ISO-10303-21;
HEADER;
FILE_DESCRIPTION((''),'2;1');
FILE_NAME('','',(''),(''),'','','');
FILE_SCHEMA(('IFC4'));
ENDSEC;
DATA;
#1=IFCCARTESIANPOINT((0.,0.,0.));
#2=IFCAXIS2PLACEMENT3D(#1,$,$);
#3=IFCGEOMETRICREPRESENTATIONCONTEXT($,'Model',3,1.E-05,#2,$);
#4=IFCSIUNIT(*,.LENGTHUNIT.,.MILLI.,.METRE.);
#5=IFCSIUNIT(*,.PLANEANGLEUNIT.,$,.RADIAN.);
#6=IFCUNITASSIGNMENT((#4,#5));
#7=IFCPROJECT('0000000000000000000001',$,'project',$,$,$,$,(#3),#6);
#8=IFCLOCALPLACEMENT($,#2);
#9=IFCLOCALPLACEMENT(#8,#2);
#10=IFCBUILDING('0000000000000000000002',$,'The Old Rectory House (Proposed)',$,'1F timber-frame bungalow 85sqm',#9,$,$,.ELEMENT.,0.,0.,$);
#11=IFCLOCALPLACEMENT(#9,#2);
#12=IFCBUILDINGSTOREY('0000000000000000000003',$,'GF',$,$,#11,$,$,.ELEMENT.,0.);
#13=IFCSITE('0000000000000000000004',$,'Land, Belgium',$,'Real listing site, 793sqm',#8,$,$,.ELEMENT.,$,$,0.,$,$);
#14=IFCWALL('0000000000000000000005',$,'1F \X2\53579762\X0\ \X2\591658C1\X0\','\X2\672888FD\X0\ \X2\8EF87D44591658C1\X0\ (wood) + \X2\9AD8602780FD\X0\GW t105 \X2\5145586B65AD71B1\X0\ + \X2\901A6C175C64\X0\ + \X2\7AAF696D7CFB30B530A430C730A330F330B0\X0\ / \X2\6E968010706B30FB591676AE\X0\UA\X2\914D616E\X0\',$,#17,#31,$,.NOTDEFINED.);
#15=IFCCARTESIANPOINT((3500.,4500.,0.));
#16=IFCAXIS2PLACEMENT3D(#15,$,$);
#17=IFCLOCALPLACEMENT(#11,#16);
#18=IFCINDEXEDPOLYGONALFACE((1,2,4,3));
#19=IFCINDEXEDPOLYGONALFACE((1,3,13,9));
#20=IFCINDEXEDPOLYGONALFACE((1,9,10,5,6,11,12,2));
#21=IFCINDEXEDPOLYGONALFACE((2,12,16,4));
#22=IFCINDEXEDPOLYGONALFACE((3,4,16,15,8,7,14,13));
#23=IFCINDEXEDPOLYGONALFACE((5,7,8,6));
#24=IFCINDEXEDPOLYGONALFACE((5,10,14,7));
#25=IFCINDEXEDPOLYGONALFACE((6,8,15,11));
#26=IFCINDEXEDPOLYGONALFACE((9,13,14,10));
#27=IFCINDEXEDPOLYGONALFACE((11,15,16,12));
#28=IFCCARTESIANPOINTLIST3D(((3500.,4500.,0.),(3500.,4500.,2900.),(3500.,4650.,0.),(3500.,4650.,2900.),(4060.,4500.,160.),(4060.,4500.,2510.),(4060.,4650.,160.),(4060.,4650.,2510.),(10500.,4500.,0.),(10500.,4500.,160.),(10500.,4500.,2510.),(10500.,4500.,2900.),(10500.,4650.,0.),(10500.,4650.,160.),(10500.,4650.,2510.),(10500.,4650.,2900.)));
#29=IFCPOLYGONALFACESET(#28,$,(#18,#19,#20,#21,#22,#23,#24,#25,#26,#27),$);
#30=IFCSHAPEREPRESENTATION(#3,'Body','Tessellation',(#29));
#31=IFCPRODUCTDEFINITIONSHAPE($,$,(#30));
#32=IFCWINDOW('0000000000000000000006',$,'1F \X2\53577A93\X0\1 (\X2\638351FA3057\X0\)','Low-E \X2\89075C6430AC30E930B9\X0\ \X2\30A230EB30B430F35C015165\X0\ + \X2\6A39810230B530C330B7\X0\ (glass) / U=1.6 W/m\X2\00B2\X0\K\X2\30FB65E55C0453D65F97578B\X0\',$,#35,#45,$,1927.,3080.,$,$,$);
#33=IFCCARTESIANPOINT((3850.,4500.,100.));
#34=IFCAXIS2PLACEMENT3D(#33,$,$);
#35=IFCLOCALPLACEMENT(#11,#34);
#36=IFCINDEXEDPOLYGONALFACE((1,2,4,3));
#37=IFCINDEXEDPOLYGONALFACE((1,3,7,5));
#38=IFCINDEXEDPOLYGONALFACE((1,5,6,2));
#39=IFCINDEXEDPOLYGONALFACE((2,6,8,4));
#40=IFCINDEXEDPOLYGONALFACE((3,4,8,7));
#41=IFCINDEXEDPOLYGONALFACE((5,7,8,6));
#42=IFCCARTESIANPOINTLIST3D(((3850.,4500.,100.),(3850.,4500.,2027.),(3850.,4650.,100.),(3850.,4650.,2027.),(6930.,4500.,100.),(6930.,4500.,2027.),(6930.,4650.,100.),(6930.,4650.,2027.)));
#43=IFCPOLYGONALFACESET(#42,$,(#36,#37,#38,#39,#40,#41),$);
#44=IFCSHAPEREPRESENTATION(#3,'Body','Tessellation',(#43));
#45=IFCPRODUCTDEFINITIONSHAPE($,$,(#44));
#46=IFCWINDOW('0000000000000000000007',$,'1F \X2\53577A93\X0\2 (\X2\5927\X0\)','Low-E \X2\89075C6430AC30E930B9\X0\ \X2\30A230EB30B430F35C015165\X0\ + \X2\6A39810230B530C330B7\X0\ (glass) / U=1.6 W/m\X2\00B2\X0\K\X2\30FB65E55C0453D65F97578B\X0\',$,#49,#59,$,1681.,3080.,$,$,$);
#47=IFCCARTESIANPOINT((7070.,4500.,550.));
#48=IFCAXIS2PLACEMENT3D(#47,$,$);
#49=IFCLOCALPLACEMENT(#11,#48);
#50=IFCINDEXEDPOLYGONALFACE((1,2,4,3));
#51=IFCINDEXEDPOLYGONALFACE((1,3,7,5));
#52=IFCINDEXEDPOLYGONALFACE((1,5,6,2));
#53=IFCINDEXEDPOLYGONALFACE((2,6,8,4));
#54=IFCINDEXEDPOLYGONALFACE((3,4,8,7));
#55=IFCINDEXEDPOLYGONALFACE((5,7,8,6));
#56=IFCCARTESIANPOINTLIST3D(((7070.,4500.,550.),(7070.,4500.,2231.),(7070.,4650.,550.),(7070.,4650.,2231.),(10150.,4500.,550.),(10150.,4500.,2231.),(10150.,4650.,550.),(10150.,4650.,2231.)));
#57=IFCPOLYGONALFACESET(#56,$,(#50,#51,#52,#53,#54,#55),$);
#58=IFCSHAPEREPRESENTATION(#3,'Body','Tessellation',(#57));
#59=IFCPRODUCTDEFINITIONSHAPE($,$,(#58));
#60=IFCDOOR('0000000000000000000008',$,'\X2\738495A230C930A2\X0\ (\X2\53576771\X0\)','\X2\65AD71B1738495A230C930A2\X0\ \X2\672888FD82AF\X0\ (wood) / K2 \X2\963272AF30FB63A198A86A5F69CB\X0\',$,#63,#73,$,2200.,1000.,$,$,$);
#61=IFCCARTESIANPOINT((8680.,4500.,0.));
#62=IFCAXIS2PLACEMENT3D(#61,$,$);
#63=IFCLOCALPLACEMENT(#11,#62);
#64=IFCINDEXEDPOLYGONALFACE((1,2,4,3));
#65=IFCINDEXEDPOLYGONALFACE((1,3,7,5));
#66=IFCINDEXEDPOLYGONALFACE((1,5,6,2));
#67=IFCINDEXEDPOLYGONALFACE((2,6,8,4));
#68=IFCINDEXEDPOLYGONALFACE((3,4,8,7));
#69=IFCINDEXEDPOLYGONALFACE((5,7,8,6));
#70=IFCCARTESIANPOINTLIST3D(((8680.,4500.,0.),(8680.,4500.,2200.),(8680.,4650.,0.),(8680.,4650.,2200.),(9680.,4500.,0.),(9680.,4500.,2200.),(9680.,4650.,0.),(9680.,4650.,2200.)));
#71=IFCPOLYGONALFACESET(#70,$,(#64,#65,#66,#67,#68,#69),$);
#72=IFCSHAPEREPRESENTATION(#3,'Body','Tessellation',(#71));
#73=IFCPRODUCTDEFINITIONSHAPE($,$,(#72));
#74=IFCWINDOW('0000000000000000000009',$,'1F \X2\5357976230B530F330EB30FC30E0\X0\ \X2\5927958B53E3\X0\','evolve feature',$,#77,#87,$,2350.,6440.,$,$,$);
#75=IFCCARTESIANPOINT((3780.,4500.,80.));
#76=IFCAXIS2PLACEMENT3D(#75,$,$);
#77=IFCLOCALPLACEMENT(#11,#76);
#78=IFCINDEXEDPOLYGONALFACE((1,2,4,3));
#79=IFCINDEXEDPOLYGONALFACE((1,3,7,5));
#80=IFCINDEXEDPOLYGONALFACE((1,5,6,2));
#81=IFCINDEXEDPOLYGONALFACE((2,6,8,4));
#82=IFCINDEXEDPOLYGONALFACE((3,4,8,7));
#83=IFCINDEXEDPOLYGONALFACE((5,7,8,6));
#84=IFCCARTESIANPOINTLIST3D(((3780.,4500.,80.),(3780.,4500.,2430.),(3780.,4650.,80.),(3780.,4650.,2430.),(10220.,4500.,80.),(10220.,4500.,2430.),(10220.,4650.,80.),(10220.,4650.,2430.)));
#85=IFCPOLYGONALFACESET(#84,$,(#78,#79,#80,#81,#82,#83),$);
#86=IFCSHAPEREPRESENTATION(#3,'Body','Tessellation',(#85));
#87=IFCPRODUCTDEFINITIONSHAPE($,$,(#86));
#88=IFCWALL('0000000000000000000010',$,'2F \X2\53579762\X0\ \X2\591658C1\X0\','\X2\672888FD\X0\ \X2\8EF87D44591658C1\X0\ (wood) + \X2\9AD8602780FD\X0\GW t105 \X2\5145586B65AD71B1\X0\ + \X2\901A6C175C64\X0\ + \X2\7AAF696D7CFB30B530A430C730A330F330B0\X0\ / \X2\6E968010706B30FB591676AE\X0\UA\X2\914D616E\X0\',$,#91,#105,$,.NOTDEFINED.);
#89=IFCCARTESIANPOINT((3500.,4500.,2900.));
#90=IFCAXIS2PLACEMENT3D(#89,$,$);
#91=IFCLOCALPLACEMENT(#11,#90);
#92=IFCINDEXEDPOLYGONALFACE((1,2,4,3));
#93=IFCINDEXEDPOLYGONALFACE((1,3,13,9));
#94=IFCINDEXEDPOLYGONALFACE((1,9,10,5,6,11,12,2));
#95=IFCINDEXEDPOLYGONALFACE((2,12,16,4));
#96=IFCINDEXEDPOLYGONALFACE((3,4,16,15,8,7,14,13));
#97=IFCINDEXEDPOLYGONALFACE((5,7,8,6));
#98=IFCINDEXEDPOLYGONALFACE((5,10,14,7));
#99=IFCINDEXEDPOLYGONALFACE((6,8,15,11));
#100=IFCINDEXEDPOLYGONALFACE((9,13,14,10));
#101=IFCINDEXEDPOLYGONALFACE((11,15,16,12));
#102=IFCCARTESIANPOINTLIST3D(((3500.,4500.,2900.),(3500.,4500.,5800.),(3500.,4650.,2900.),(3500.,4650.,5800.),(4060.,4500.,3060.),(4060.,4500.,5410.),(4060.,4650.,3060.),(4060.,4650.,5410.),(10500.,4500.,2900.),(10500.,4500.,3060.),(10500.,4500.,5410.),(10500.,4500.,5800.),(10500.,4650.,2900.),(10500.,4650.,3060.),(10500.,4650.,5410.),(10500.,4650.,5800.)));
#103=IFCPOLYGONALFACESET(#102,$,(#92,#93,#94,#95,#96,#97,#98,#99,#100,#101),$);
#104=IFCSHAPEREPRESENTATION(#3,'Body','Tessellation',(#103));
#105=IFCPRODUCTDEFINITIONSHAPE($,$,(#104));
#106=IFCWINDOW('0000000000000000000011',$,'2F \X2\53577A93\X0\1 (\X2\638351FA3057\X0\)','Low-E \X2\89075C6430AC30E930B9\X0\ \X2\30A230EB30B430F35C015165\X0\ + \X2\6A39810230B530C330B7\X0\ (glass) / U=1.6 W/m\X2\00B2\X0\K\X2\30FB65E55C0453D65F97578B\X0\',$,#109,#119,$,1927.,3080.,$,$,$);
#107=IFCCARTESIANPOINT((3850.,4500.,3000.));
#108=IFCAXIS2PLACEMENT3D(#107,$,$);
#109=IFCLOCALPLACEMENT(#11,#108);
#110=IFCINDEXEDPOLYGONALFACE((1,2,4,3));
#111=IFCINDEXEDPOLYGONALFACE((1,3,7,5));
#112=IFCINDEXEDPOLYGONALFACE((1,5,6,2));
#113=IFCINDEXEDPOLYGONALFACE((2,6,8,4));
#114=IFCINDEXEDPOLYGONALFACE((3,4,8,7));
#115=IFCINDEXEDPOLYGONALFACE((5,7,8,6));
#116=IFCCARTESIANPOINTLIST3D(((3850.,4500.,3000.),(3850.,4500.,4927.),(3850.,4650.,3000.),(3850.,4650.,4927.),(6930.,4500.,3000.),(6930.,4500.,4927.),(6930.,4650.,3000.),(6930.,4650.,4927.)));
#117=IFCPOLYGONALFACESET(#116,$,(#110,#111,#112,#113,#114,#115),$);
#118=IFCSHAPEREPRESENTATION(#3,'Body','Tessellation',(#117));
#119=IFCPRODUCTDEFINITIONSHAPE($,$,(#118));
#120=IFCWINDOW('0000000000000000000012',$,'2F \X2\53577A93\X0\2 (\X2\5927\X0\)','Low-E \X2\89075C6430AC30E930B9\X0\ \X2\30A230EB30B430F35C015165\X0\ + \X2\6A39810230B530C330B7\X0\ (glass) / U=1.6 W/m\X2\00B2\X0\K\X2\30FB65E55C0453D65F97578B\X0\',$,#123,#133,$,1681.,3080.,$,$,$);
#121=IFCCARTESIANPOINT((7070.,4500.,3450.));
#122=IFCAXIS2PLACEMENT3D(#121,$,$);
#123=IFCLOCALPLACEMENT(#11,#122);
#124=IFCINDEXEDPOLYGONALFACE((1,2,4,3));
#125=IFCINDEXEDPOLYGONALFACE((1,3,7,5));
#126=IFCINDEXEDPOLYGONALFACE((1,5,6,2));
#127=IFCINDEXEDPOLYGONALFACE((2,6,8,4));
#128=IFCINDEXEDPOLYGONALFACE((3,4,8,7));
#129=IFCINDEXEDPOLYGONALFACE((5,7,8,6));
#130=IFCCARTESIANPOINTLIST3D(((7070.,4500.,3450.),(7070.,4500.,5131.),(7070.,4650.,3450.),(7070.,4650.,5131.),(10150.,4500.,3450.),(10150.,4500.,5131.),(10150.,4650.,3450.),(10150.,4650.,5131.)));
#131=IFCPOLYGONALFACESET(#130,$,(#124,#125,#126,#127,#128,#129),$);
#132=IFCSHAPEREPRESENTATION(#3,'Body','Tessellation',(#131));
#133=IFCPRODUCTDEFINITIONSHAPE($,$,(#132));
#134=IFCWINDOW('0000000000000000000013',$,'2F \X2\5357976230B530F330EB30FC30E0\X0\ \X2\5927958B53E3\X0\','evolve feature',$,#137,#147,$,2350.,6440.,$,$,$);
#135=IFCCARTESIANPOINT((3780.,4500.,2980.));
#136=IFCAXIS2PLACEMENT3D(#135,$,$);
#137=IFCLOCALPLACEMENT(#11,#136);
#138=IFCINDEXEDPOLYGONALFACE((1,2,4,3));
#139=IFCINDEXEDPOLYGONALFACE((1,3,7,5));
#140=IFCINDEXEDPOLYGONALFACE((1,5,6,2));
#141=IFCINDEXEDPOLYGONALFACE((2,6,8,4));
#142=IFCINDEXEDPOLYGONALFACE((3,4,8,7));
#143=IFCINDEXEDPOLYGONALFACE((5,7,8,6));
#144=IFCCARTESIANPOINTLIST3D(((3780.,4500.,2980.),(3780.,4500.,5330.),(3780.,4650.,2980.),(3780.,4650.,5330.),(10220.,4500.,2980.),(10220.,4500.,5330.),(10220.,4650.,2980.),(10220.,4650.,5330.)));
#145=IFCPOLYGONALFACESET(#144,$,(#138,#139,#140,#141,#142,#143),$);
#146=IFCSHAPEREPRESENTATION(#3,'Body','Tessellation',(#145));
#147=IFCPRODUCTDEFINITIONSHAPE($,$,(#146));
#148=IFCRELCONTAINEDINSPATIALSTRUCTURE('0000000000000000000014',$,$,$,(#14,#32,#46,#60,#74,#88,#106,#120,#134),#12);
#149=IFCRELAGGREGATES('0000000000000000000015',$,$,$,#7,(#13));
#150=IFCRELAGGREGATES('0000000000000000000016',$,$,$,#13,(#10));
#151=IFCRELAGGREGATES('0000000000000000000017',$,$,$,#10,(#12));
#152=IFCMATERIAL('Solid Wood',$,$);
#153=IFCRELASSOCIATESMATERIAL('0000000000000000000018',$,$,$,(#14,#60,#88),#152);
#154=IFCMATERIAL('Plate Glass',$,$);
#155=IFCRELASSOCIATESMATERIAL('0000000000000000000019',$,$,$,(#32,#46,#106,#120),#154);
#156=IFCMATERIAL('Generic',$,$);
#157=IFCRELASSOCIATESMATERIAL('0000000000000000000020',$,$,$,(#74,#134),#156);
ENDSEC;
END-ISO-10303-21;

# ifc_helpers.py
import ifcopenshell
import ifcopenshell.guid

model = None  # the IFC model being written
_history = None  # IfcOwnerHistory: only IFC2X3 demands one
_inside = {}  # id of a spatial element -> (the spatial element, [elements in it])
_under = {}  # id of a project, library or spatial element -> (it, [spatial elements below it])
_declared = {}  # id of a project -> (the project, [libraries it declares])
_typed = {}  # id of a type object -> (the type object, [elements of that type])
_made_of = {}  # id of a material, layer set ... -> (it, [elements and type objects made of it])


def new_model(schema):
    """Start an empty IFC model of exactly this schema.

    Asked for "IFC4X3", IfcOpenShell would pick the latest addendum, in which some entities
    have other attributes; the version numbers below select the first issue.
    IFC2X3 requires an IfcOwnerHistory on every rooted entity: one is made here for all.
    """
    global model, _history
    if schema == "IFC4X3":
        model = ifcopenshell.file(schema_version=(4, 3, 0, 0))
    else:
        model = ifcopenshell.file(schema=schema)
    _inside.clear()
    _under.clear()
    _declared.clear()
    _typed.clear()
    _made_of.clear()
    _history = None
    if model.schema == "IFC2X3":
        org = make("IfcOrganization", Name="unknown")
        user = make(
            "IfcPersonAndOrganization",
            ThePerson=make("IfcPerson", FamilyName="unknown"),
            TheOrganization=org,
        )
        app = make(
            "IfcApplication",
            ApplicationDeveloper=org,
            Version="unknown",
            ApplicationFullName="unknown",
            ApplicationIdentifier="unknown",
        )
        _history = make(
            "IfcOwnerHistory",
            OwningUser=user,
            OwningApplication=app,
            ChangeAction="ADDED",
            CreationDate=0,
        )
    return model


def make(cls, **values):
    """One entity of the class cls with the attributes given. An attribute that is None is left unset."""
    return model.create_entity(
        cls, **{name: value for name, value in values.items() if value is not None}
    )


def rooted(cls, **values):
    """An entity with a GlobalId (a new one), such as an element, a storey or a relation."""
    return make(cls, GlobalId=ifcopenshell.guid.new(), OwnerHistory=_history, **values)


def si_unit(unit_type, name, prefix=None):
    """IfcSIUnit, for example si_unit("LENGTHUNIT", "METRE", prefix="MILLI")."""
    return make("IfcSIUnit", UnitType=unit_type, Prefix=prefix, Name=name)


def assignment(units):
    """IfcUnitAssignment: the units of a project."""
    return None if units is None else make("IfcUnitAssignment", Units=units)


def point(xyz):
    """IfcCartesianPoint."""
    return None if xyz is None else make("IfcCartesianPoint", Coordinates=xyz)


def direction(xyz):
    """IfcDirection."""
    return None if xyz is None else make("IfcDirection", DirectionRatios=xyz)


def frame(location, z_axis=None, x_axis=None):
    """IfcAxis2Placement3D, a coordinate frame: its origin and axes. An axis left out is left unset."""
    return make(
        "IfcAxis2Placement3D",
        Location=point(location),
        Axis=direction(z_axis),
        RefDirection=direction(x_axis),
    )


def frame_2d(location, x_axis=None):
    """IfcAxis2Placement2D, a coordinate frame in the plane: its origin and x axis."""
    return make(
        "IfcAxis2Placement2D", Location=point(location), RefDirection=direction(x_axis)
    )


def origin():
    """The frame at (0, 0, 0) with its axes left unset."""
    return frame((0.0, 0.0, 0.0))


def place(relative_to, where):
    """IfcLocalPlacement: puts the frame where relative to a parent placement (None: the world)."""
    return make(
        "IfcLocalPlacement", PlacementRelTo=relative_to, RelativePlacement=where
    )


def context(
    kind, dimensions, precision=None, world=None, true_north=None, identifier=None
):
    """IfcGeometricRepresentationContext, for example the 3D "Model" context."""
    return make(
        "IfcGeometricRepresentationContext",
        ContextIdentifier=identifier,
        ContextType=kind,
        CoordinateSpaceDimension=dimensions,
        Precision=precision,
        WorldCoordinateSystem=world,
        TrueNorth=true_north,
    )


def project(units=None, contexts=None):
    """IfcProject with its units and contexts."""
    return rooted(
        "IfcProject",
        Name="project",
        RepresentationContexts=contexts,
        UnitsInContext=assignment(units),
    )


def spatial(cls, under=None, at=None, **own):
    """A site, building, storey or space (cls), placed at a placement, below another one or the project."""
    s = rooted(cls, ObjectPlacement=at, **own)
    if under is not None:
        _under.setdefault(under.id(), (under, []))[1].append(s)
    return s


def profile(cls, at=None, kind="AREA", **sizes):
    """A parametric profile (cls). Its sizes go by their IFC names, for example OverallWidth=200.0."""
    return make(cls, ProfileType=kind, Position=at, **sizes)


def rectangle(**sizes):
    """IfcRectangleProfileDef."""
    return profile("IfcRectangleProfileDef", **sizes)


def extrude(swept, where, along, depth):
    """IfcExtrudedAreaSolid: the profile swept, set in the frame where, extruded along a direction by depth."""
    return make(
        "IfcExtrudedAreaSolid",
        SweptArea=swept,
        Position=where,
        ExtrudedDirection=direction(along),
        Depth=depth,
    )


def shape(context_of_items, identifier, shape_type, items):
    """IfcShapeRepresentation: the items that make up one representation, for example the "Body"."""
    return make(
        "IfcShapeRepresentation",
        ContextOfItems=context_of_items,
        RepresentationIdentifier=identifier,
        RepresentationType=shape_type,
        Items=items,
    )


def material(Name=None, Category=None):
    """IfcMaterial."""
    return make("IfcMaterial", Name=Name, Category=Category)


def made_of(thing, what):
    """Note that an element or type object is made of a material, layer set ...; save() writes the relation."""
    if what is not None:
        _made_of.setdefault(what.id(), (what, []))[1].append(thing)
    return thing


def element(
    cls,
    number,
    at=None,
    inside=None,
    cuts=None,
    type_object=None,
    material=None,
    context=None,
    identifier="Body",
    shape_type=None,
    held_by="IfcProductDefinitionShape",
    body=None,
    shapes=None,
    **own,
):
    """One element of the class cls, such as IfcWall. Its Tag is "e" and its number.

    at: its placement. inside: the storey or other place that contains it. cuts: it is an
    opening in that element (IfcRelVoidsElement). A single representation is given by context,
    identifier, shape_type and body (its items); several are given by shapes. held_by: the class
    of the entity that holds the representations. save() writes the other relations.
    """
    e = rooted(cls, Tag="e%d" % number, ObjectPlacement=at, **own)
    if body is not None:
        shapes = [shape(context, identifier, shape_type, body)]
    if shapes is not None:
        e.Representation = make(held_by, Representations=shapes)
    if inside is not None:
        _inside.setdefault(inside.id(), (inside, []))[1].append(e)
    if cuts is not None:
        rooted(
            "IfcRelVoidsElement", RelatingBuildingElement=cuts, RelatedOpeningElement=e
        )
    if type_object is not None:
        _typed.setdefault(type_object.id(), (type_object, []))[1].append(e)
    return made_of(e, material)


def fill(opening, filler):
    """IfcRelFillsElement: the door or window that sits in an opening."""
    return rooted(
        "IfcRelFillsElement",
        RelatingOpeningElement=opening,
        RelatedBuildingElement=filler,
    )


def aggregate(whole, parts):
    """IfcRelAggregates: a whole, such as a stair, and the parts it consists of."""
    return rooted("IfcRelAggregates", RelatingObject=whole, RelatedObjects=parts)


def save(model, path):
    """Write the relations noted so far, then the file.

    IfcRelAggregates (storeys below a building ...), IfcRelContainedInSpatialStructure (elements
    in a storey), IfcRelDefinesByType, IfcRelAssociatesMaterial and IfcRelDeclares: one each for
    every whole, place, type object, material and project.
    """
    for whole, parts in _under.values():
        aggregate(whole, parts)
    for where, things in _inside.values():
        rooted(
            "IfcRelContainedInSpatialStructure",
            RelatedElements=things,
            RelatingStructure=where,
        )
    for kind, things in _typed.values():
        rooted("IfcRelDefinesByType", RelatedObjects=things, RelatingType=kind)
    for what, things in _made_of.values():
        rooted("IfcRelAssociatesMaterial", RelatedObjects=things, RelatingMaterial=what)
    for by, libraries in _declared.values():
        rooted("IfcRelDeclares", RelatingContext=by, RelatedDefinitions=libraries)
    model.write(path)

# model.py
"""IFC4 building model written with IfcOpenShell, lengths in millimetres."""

from ifc_helpers import new_model, si_unit, frame, frame_2d, origin, place, context, project, spatial, rectangle, extrude, material, element, fill, save


model = new_model("IFC4")

# Units and contexts
model_context = context("Model", 3, precision=1e-05, world=origin())
ifc_project = project(units=[si_unit("LENGTHUNIT", "METRE", prefix="MILLI"), si_unit("PLANEANGLEUNIT", "RADIAN")], contexts=[model_context])

# Site, building, storey
site_placement = place(None, origin())
site = spatial("IfcSite", under=ifc_project, at=site_placement, Name="Land, Belgium", ObjectType="Real listing site, 793sqm", CompositionType="ELEMENT", RefElevation=0.0)
building_placement = place(site_placement, origin())
building = spatial("IfcBuilding", under=site, at=building_placement, Name="The Old Rectory House (Proposed)", ObjectType="1F timber-frame bungalow 85sqm", CompositionType="ELEMENT", ElevationOfRefHeight=0.0, ElevationOfTerrain=0.0)
storey_placement = place(building_placement, origin())
storey = spatial("IfcBuildingStorey", under=building, at=storey_placement, Name="GF", CompositionType="ELEMENT", Elevation=0.0)

# Shared definitions
ifc_material_1 = material(Name="Solid Wood")
ifc_material_2 = material(Name="Generic")

# Wall, openings, windows, door
wall_1_placement = place(storey_placement, frame((3500.0, 4500.0, 0.0)))
wall_1 = element("IfcWall", 1, at=wall_1_placement, inside=storey, material=ifc_material_1, Name="1F 南面 外壁", Description="木製 軸組外壁 (wood) + 高性能GW t105 充填断熱 + 通気層 + 窯業系サイディング / 準耐火・外皮UA配慮", PredefinedType="NOTDEFINED", context=model_context, shape_type="SweptSolid", body=[
    extrude(rectangle(XDim=7000.0, YDim=150.0, at=frame_2d((3500.0, 75.0))), frame((3500.0, 4500.0, 0.0)), (0.0, 0.0, 1.0), 2900.0),
])
opening_1_placement = place(storey_placement, frame((3850.0, 4500.0, 100.0)))
opening_1 = element("IfcOpeningElement", 2, at=opening_1_placement, cuts=wall_1, PredefinedType="NOTDEFINED", context=model_context, shape_type="SweptSolid", body=[
    extrude(rectangle(XDim=3080.0, YDim=150.0, at=frame_2d((1540.0, 75.0))), frame((3850.0, 4500.0, 100.0)), (0.0, 0.0, 1.0), 1927.0),
])
opening_2_placement = place(storey_placement, frame((7070.0, 4500.0, 550.0)))
opening_2 = element("IfcOpeningElement", 3, at=opening_2_placement, cuts=wall_1, PredefinedType="NOTDEFINED", context=model_context, shape_type="SweptSolid", body=[
    extrude(rectangle(XDim=3080.0, YDim=150.0, at=frame_2d((1540.0, 75.0))), frame((7070.0, 4500.0, 550.0)), (0.0, 0.0, 1.0), 1681.0),
])
opening_3_placement = place(storey_placement, frame((8680.0, 4500.0, 0.0)))
opening_3 = element("IfcOpeningElement", 4, at=opening_3_placement, cuts=wall_1, PredefinedType="NOTDEFINED", context=model_context, shape_type="SweptSolid", body=[
    extrude(rectangle(XDim=1000.0, YDim=150.0, at=frame_2d((500.0, 75.0))), frame((8680.0, 4500.0, 0.0)), (0.0, 0.0, 1.0), 2200.0),
])
opening_4_placement = place(storey_placement, frame((3780.0, 4500.0, 80.0)))
opening_4 = element("IfcOpeningElement", 5, at=opening_4_placement, cuts=wall_1, PredefinedType="NOTDEFINED", context=model_context, shape_type="SweptSolid", body=[
    extrude(rectangle(XDim=6440.0, YDim=150.0, at=frame_2d((3220.0, 75.0))), frame((3780.0, 4500.0, 80.0)), (0.0, 0.0, 1.0), 2350.0),
])
ifc_material_3 = material(Name="Plate Glass")
window_1_placement = place(storey_placement, frame((3850.0, 4500.0, 100.0)))
window_1 = element("IfcWindow", 6, at=window_1_placement, inside=storey, material=ifc_material_3, Name="1F 南窓1 (掃出し)", Description="Low-E 複層ガラス アルゴン封入 + 樹脂サッシ (glass) / U=1.6 W/m²K・日射取得型", OverallHeight=1927.0, OverallWidth=3080.0, context=model_context, shape_type="SweptSolid", body=[
    extrude(rectangle(XDim=3080.0, YDim=150.0, at=frame_2d((1540.0, 75.0))), frame((3850.0, 4500.0, 100.0)), (0.0, 0.0, 1.0), 1927.0),
])
fill(opening_1, window_1)
window_2_placement = place(storey_placement, frame((7070.0, 4500.0, 550.0)))
window_2 = element("IfcWindow", 7, at=window_2_placement, inside=storey, material=ifc_material_3, Name="1F 南窓2 (大)", Description="Low-E 複層ガラス アルゴン封入 + 樹脂サッシ (glass) / U=1.6 W/m²K・日射取得型", OverallHeight=1681.0, OverallWidth=3080.0, context=model_context, shape_type="SweptSolid", body=[
    extrude(rectangle(XDim=3080.0, YDim=150.0, at=frame_2d((1540.0, 75.0))), frame((7070.0, 4500.0, 550.0)), (0.0, 0.0, 1.0), 1681.0),
])
fill(opening_2, window_2)
door_placement = place(storey_placement, frame((8680.0, 4500.0, 0.0)))
door = element("IfcDoor", 8, at=door_placement, inside=storey, material=ifc_material_1, Name="玄関ドア (南東)", Description="断熱玄関ドア 木製芯 (wood) / K2 防犯・採風機構", OverallHeight=2200.0, OverallWidth=1000.0, context=model_context, shape_type="SweptSolid", body=[
    extrude(rectangle(XDim=1000.0, YDim=150.0, at=frame_2d((500.0, 75.0))), frame((8680.0, 4500.0, 0.0)), (0.0, 0.0, 1.0), 2200.0),
])
fill(opening_3, door)
window_3_placement = place(storey_placement, frame((3780.0, 4500.0, 80.0)))
window_3 = element("IfcWindow", 9, at=window_3_placement, inside=storey, material=ifc_material_2, Name="1F 南面サンルーム 大開口", Description="evolve feature", OverallHeight=2350.0, OverallWidth=6440.0, context=model_context, shape_type="SweptSolid", body=[
    extrude(rectangle(XDim=6440.0, YDim=150.0, at=frame_2d((3220.0, 75.0))), frame((3780.0, 4500.0, 80.0)), (0.0, 0.0, 1.0), 2350.0),
])
fill(opening_4, window_3)

# Wall, openings, windows
wall_2_placement = place(storey_placement, frame((3500.0, 4500.0, 2900.0)))
wall_2 = element("IfcWall", 10, at=wall_2_placement, inside=storey, material=ifc_material_1, Name="2F 南面 外壁", Description="木製 軸組外壁 (wood) + 高性能GW t105 充填断熱 + 通気層 + 窯業系サイディング / 準耐火・外皮UA配慮", PredefinedType="NOTDEFINED", context=model_context, shape_type="SweptSolid", body=[
    extrude(rectangle(XDim=7000.0, YDim=150.0, at=frame_2d((3500.0, 75.0))), frame((3500.0, 4500.0, 2900.0)), (0.0, 0.0, 1.0), 2900.0),
])
opening_5_placement = place(storey_placement, frame((3850.0, 4500.0, 3000.0)))
opening_5 = element("IfcOpeningElement", 11, at=opening_5_placement, cuts=wall_2, PredefinedType="NOTDEFINED", context=model_context, shape_type="SweptSolid", body=[
    extrude(rectangle(XDim=3080.0, YDim=150.0, at=frame_2d((1540.0, 75.0))), frame((3850.0, 4500.0, 3000.0)), (0.0, 0.0, 1.0), 1927.0),
])
opening_6_placement = place(storey_placement, frame((7070.0, 4500.0, 3450.0)))
opening_6 = element("IfcOpeningElement", 12, at=opening_6_placement, cuts=wall_2, PredefinedType="NOTDEFINED", context=model_context, shape_type="SweptSolid", body=[
    extrude(rectangle(XDim=3080.0, YDim=150.0, at=frame_2d((1540.0, 75.0))), frame((7070.0, 4500.0, 3450.0)), (0.0, 0.0, 1.0), 1681.0),
])
opening_7_placement = place(storey_placement, frame((3780.0, 4500.0, 2980.0)))
opening_7 = element("IfcOpeningElement", 13, at=opening_7_placement, cuts=wall_2, PredefinedType="NOTDEFINED", context=model_context, shape_type="SweptSolid", body=[
    extrude(rectangle(XDim=6440.0, YDim=150.0, at=frame_2d((3220.0, 75.0))), frame((3780.0, 4500.0, 2980.0)), (0.0, 0.0, 1.0), 2350.0),
])
window_4_placement = place(storey_placement, frame((3850.0, 4500.0, 3000.0)))
window_4 = element("IfcWindow", 14, at=window_4_placement, inside=storey, material=ifc_material_3, Name="2F 南窓1 (掃出し)", Description="Low-E 複層ガラス アルゴン封入 + 樹脂サッシ (glass) / U=1.6 W/m²K・日射取得型", OverallHeight=1927.0, OverallWidth=3080.0, context=model_context, shape_type="SweptSolid", body=[
    extrude(rectangle(XDim=3080.0, YDim=150.0, at=frame_2d((1540.0, 75.0))), frame((3850.0, 4500.0, 3000.0)), (0.0, 0.0, 1.0), 1927.0),
])
fill(opening_5, window_4)
window_5_placement = place(storey_placement, frame((7070.0, 4500.0, 3450.0)))
window_5 = element("IfcWindow", 15, at=window_5_placement, inside=storey, material=ifc_material_3, Name="2F 南窓2 (大)", Description="Low-E 複層ガラス アルゴン封入 + 樹脂サッシ (glass) / U=1.6 W/m²K・日射取得型", OverallHeight=1681.0, OverallWidth=3080.0, context=model_context, shape_type="SweptSolid", body=[
    extrude(rectangle(XDim=3080.0, YDim=150.0, at=frame_2d((1540.0, 75.0))), frame((7070.0, 4500.0, 3450.0)), (0.0, 0.0, 1.0), 1681.0),
])
fill(opening_6, window_5)
window_6_placement = place(storey_placement, frame((3780.0, 4500.0, 2980.0)))
window_6 = element("IfcWindow", 16, at=window_6_placement, inside=storey, material=ifc_material_2, Name="2F 南面サンルーム 大開口", Description="evolve feature", OverallHeight=2350.0, OverallWidth=6440.0, context=model_context, shape_type="SweptSolid", body=[
    extrude(rectangle(XDim=6440.0, YDim=150.0, at=frame_2d((3220.0, 75.0))), frame((3780.0, 4500.0, 2980.0)), (0.0, 0.0, 1.0), 2350.0),
])
fill(opening_7, window_6)

save(model, "model.ifc")
